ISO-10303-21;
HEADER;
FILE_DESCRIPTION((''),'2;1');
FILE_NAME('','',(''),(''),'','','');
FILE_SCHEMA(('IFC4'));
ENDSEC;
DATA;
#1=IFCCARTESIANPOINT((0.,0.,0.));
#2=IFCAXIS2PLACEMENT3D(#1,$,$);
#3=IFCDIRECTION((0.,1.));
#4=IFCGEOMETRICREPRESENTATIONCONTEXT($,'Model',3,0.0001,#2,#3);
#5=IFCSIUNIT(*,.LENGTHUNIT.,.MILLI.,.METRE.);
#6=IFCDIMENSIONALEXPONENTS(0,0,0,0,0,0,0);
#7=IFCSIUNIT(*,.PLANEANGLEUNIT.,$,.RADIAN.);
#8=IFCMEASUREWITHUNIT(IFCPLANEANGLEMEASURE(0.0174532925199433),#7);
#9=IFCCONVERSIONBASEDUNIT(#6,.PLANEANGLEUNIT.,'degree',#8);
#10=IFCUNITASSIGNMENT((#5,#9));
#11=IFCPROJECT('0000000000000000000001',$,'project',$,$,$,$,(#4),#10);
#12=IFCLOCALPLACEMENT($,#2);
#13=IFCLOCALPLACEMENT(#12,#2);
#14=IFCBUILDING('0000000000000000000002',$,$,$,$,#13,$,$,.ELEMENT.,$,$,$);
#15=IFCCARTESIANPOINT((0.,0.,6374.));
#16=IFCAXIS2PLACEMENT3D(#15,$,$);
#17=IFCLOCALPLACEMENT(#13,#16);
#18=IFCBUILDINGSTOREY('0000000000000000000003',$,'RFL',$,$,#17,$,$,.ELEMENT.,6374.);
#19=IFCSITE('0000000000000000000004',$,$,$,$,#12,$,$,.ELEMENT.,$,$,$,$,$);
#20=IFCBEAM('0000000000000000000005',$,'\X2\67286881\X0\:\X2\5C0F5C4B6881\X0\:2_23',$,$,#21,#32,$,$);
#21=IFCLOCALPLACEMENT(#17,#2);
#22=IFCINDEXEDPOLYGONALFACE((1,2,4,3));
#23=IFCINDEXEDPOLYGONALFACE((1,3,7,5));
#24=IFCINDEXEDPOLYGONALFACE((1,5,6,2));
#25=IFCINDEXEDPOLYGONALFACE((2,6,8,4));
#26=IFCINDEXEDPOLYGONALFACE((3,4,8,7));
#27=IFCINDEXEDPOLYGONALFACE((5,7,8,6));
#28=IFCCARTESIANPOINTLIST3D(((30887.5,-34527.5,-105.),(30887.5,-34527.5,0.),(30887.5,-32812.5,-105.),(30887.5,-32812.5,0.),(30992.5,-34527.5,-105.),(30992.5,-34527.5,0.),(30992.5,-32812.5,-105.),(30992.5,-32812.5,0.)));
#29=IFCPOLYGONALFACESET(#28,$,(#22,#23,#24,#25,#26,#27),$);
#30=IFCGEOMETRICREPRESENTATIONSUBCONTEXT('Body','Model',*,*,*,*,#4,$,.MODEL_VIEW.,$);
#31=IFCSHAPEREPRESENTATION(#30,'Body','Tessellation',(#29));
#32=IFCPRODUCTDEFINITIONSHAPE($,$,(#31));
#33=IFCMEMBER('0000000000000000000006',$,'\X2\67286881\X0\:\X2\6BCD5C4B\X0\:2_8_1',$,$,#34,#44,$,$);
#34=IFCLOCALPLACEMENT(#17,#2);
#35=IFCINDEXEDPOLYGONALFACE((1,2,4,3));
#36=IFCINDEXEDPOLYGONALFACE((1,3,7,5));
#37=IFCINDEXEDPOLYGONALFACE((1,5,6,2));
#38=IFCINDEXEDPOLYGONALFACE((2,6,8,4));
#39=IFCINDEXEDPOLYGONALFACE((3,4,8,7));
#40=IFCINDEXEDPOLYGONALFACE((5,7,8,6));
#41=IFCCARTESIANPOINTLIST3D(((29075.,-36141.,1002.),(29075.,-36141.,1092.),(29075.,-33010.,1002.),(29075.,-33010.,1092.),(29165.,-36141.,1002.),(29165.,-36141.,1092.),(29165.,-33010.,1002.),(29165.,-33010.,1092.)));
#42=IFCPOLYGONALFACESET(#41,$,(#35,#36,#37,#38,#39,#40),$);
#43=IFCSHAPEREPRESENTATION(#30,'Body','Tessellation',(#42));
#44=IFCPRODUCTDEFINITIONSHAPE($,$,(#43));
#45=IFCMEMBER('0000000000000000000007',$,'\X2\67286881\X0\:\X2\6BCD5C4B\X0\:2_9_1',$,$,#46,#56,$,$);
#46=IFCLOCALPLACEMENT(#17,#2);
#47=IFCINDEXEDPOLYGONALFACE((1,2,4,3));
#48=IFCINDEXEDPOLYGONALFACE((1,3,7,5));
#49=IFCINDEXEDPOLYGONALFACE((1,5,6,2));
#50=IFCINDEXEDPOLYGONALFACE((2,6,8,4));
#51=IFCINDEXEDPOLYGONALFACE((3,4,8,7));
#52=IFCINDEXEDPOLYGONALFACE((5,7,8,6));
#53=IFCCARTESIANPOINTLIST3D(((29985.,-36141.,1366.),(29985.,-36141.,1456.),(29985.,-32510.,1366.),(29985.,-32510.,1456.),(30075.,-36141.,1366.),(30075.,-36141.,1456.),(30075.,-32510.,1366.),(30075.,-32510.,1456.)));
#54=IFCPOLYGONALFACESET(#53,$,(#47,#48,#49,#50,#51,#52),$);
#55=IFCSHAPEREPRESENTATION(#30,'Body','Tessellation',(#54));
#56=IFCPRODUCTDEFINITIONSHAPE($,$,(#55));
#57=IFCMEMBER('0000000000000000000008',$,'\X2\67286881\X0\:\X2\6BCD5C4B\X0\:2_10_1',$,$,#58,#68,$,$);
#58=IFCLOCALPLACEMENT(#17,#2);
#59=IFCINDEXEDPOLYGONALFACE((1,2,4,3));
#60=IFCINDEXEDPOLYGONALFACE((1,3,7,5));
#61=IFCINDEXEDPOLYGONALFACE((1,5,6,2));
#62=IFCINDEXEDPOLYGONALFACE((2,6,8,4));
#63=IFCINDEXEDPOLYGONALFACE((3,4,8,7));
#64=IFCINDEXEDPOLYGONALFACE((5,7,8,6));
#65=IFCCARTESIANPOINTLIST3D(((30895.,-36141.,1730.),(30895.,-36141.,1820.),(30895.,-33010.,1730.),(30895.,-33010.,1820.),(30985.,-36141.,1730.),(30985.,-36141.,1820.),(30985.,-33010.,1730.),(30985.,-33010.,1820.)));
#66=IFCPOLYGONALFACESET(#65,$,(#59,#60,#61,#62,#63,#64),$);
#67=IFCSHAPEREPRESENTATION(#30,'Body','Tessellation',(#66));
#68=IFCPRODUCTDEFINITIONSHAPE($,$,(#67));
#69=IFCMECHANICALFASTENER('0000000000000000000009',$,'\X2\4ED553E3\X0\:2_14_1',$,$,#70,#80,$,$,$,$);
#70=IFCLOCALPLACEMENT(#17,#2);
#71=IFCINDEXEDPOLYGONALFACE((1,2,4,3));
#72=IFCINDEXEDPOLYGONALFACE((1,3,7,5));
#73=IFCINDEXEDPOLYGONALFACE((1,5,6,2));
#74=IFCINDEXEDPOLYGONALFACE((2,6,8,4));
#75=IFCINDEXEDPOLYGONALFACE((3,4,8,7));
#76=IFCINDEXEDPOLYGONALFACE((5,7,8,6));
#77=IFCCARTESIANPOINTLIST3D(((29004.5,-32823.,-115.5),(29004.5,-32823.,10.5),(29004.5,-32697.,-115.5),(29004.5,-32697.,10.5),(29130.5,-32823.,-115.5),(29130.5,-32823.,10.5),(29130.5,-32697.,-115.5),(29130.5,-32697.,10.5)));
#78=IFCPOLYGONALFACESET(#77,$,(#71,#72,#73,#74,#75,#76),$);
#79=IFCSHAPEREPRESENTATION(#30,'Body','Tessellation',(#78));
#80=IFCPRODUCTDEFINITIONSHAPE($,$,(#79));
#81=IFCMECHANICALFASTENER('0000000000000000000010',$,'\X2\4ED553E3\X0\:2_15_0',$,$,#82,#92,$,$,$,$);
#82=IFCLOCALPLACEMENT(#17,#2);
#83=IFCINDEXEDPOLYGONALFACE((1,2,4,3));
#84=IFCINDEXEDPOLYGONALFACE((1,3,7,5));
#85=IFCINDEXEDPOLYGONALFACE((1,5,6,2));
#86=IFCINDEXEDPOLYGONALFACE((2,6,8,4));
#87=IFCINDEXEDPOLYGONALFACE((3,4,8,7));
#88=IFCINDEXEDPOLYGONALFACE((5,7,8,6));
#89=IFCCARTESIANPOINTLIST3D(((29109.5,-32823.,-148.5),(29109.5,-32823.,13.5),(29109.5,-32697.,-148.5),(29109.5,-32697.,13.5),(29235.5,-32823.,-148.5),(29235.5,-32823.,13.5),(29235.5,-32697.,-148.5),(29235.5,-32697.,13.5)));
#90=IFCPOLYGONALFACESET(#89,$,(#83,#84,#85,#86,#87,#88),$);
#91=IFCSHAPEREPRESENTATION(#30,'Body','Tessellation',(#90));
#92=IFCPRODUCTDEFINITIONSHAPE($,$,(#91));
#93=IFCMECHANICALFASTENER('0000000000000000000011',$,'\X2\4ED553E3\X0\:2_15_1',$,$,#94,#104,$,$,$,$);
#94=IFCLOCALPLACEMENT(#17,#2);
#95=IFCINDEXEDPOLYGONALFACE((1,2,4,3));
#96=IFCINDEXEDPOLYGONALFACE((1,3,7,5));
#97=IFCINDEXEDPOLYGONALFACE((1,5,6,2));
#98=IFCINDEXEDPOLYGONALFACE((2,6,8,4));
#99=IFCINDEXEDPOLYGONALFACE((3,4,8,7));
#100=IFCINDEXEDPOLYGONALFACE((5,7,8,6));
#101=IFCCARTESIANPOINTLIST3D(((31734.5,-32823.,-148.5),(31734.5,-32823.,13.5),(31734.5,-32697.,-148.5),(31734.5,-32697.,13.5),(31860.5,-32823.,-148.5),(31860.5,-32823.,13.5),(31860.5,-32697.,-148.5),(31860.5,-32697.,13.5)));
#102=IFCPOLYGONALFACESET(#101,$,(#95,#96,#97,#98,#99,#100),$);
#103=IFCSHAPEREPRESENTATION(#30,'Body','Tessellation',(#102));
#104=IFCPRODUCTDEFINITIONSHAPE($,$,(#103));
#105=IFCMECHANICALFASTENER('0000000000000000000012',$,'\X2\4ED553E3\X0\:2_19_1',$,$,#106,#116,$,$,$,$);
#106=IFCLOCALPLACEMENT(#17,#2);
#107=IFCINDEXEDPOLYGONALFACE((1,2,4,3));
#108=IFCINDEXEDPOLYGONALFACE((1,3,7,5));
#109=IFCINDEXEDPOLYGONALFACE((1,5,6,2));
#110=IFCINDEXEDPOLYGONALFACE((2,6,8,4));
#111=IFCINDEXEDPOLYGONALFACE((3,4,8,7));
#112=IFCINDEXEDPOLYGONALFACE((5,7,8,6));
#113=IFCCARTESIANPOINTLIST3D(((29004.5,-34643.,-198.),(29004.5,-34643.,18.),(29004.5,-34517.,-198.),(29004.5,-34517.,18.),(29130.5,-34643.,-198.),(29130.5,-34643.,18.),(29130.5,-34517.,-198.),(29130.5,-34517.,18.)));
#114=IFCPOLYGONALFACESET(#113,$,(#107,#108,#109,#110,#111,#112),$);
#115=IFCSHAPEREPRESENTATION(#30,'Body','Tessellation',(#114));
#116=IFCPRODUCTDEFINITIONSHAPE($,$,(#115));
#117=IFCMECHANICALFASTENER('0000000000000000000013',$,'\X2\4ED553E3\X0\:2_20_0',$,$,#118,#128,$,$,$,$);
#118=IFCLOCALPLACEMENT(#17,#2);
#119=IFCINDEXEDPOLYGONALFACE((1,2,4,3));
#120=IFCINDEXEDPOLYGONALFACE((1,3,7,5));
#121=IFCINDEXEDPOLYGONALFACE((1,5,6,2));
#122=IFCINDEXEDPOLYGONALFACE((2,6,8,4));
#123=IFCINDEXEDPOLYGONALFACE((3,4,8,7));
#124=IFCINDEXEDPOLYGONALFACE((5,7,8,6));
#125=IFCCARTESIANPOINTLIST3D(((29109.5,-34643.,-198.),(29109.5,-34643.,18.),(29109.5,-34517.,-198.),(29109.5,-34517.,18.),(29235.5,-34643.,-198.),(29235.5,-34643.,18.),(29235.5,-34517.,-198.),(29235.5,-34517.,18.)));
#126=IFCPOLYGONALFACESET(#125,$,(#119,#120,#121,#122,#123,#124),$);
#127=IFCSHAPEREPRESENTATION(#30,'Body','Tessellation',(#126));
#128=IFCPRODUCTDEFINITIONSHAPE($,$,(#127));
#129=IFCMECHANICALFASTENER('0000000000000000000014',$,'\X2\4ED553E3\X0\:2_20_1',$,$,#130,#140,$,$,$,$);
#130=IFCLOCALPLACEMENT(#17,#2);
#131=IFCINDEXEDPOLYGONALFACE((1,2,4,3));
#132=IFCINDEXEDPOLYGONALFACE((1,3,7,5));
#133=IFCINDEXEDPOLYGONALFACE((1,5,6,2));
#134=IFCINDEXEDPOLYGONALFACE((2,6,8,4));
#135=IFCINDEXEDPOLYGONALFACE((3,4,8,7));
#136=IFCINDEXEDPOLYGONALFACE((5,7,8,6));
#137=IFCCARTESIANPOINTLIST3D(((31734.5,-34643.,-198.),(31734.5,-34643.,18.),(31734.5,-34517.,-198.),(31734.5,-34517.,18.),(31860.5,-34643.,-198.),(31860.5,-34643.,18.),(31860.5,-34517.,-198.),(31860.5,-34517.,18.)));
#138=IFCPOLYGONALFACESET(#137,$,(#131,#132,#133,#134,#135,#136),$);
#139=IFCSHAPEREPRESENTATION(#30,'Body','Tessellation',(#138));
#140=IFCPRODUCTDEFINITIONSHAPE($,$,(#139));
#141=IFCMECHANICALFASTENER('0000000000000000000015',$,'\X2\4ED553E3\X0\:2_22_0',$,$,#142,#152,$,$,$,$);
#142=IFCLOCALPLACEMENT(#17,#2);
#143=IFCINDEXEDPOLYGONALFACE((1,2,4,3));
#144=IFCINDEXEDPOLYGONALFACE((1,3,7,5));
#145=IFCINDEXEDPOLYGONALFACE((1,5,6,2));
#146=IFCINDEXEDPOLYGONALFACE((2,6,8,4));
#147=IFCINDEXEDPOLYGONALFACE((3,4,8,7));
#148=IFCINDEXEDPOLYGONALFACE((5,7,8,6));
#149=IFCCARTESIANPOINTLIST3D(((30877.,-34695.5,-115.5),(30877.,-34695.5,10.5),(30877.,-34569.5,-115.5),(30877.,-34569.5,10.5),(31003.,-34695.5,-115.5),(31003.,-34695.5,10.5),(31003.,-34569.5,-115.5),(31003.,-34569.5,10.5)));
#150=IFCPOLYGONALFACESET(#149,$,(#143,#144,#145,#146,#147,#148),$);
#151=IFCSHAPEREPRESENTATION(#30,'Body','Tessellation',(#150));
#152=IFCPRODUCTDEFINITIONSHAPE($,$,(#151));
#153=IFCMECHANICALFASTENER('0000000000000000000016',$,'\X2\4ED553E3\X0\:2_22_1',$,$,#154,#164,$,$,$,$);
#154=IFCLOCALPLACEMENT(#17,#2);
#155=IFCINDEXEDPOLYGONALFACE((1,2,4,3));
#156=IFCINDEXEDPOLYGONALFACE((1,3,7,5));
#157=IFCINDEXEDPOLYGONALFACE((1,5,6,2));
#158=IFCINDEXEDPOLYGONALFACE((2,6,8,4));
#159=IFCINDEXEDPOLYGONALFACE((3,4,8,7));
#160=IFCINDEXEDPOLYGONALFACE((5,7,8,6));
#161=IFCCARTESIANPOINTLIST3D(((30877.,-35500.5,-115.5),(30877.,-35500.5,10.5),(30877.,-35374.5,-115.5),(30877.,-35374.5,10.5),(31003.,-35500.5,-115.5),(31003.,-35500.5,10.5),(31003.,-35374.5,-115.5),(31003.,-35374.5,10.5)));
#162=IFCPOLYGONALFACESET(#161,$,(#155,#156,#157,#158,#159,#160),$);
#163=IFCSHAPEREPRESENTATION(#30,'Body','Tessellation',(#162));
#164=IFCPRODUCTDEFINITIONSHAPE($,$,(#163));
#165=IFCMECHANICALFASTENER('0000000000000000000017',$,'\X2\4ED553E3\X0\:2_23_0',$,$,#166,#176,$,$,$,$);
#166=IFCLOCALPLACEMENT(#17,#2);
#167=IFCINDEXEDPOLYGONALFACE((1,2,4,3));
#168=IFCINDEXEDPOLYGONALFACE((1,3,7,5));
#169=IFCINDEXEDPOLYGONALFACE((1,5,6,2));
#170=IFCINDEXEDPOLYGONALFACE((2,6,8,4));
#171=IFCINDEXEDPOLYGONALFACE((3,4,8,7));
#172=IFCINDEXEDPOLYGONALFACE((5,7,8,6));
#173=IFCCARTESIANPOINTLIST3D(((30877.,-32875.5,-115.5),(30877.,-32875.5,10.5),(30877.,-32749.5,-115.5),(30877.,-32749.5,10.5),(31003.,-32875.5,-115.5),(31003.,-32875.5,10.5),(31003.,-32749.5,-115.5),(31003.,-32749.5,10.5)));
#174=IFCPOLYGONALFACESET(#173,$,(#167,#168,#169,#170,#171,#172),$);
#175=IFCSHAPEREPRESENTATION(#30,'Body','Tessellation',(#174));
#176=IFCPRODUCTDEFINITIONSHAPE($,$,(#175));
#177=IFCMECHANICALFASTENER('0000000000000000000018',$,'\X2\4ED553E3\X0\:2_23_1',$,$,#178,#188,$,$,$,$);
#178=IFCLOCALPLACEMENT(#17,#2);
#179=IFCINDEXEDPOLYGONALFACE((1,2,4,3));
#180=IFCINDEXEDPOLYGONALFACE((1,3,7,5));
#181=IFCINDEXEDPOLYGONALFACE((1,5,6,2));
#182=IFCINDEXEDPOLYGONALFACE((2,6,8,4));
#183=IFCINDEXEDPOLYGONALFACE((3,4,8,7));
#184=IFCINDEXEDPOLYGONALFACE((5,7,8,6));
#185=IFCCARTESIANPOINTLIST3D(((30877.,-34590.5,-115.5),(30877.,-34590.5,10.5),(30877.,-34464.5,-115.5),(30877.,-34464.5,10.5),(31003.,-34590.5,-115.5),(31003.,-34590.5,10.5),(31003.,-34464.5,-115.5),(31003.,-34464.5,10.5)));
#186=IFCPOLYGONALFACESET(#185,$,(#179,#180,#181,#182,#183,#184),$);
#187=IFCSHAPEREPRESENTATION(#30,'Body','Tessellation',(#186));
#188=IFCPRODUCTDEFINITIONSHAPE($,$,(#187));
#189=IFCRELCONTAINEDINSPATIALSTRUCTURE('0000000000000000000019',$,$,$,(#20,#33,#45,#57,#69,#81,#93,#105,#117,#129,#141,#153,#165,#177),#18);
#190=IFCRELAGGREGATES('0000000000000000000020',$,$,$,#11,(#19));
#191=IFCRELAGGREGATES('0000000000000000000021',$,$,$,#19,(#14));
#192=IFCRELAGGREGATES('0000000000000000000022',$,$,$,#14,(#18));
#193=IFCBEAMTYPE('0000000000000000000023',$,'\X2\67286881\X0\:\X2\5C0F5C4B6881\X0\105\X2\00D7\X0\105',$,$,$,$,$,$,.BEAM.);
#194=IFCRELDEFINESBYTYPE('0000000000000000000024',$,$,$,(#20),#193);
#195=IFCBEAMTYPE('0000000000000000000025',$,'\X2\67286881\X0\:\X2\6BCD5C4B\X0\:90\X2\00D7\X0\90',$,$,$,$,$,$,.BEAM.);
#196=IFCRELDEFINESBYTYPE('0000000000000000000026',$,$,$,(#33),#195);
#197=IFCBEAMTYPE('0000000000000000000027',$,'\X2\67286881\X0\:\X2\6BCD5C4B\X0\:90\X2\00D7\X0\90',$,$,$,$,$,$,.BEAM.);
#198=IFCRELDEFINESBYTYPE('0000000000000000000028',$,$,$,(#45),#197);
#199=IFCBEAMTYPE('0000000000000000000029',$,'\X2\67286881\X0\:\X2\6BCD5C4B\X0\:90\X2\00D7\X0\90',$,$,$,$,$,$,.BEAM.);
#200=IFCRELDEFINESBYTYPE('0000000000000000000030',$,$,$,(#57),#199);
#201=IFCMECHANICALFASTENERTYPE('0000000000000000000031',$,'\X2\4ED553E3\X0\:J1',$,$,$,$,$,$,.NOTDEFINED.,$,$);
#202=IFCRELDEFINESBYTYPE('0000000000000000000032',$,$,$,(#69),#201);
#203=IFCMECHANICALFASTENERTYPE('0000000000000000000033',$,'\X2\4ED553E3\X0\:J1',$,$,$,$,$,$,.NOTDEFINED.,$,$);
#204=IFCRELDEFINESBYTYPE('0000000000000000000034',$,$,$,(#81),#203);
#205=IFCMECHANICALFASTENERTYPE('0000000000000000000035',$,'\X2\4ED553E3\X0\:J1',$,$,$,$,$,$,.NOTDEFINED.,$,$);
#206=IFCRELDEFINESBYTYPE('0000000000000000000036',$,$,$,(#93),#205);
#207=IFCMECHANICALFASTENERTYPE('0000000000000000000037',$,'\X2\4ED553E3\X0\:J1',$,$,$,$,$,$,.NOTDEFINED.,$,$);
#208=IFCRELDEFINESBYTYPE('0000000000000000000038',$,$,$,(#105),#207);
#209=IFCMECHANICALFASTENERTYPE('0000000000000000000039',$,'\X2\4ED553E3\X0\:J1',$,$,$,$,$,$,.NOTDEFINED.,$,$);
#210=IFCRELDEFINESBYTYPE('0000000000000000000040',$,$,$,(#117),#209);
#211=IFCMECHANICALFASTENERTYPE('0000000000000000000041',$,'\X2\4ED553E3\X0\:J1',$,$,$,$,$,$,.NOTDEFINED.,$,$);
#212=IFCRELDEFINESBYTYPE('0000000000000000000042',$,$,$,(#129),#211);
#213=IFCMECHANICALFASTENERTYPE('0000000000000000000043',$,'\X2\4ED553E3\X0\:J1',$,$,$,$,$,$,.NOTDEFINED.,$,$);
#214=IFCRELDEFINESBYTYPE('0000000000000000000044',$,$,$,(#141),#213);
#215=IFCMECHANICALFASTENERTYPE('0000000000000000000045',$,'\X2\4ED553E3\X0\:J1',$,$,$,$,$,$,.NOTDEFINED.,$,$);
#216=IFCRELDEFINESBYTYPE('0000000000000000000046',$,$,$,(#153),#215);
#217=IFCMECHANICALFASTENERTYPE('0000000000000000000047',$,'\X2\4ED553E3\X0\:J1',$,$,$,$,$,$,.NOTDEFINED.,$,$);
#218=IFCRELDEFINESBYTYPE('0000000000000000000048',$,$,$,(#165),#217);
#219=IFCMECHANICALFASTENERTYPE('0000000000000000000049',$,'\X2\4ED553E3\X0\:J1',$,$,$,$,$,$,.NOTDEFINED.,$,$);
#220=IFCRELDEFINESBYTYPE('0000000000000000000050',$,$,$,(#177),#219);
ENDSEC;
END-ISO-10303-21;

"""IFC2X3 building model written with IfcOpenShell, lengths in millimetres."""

from ifc_helpers import new_model, entity, si_unit, converted_unit, direction, frame, origin, origin_with_axes, origin_2d, place, context, subcontext, project, spatial, rectangle, extrude, type_object, element, save


model = new_model("IFC2X3")

# Units and contexts
model_context = context("Model", 3, precision=0.0001, world=origin(), true_north=direction((0.0, 1.0)))
body_context = subcontext(model_context, "Body", "Model", "MODEL_VIEW")
ifc_project = project(units=[si_unit("LENGTHUNIT", "METRE", prefix="MILLI"), converted_unit("PLANEANGLEUNIT", "degree", entity("IfcPlaneAngleMeasure", 0.0174532925199433), si_unit("PLANEANGLEUNIT", "RADIAN"), dimensions=[0, 0, 0, 0, 0, 0, 0])], contexts=[model_context])

# Site, building, storey
site_placement = place(None, origin())
site = spatial("IfcSite", under=ifc_project, at=site_placement, CompositionType="ELEMENT")
building_placement = place(site_placement, origin())
building = spatial("IfcBuilding", under=site, at=building_placement, CompositionType="ELEMENT")
storey_placement = place(building_placement, frame((0.0, 0.0, 6374.0)))
storey = spatial("IfcBuildingStorey", under=building, at=storey_placement, Name="RFL", CompositionType="ELEMENT", Elevation=6374.0)

# Beam
beam_type_1 = type_object("IfcBeamType", Name="木梁:小屋梁105×105", PredefinedType="BEAM")
beam_1_placement = place(storey_placement, frame((30940.0, -32812.5, -52.5), z_axis=(0.0, -1.0, 0.0), x_axis=(1.0, 0.0, 0.0)))
element("IfcBeam", 1, at=beam_1_placement, inside=storey, type_object=beam_type_1, Name="木梁:小屋梁:2_23", context=body_context, shape_type="SweptSolid", body=[
    extrude(rectangle(XDim=105.0, YDim=105.0, at=origin_2d()), origin_with_axes(), (0.0, 0.0, 1.0), 1715.0),
])

# Members
beam_type_2 = type_object("IfcBeamType", Name="木梁:母屋:90×90", PredefinedType="BEAM")
member_1_placement = place(storey_placement, frame((29120.0, -33010.0, 1047.0), z_axis=(0.0, -1.0, 0.0), x_axis=(-1.0, 0.0, 0.0)))
element("IfcMember", 2, at=member_1_placement, inside=storey, type_object=beam_type_2, Name="木梁:母屋:2_8_1", context=body_context, shape_type="SweptSolid", body=[
    extrude(rectangle(XDim=90.0, YDim=90.0, at=origin_2d()), origin_with_axes(), (0.0, 0.0, 1.0), 3131.0),
])
beam_type_3 = type_object("IfcBeamType", Name="木梁:母屋:90×90", PredefinedType="BEAM")
member_2_placement = place(storey_placement, frame((30030.0, -32510.0, 1411.0), z_axis=(0.0, -1.0, 0.0), x_axis=(-1.0, 0.0, 0.0)))
element("IfcMember", 3, at=member_2_placement, inside=storey, type_object=beam_type_3, Name="木梁:母屋:2_9_1", context=body_context, shape_type="SweptSolid", body=[
    extrude(rectangle(XDim=90.0, YDim=90.0, at=origin_2d()), origin_with_axes(), (0.0, 0.0, 1.0), 3631.0),
])
beam_type_4 = type_object("IfcBeamType", Name="木梁:母屋:90×90", PredefinedType="BEAM")
member_3_placement = place(storey_placement, frame((30940.0, -33010.0, 1775.0), z_axis=(0.0, -1.0, 0.0), x_axis=(-1.0, 0.0, 0.0)))
element("IfcMember", 4, at=member_3_placement, inside=storey, type_object=beam_type_4, Name="木梁:母屋:2_10_1", context=body_context, shape_type="SweptSolid", body=[
    extrude(rectangle(XDim=90.0, YDim=90.0, at=origin_2d()), origin_with_axes(), (0.0, 0.0, 1.0), 3131.0),
])

# Mechanical fasteners
mechanical_fastener_type_1 = type_object("IfcMechanicalFastenerType", Name="仕口:J1")
mechanical_fastener_1_placement = place(storey_placement, frame((29067.5, -32760.0, -115.5)))
element("IfcMechanicalFastener", 5, at=mechanical_fastener_1_placement, inside=storey, type_object=mechanical_fastener_type_1, Name="仕口:2_14_1", context=body_context, shape_type="SweptSolid", body=[
    extrude(rectangle(XDim=126.0, YDim=126.0, at=origin_2d()), origin_with_axes(), (0.0, 0.0, 1.0), 126.0),
])
mechanical_fastener_type_2 = type_object("IfcMechanicalFastenerType", Name="仕口:J1")
mechanical_fastener_2_placement = place(storey_placement, frame((29172.5, -32760.0, -148.5)))
element("IfcMechanicalFastener", 6, at=mechanical_fastener_2_placement, inside=storey, type_object=mechanical_fastener_type_2, Name="仕口:2_15_0", context=body_context, shape_type="SweptSolid", body=[
    extrude(rectangle(XDim=126.0, YDim=126.0, at=origin_2d()), origin_with_axes(), (0.0, 0.0, 1.0), 162.0),
])
mechanical_fastener_type_3 = type_object("IfcMechanicalFastenerType", Name="仕口:J1")
mechanical_fastener_3_placement = place(storey_placement, frame((31797.5, -32760.0, -148.5)))
element("IfcMechanicalFastener", 7, at=mechanical_fastener_3_placement, inside=storey, type_object=mechanical_fastener_type_3, Name="仕口:2_15_1", context=body_context, shape_type="SweptSolid", body=[
    extrude(rectangle(XDim=126.0, YDim=126.0, at=origin_2d()), origin_with_axes(), (0.0, 0.0, 1.0), 162.0),
])
mechanical_fastener_type_4 = type_object("IfcMechanicalFastenerType", Name="仕口:J1")
mechanical_fastener_4_placement = place(storey_placement, frame((29067.5, -34580.0, -198.0)))
element("IfcMechanicalFastener", 8, at=mechanical_fastener_4_placement, inside=storey, type_object=mechanical_fastener_type_4, Name="仕口:2_19_1", context=body_context, shape_type="SweptSolid", body=[
    extrude(rectangle(XDim=126.0, YDim=126.0, at=origin_2d()), origin_with_axes(), (0.0, 0.0, 1.0), 216.0),
])
mechanical_fastener_type_5 = type_object("IfcMechanicalFastenerType", Name="仕口:J1")
mechanical_fastener_5_placement = place(storey_placement, frame((29172.5, -34580.0, -198.0)))
element("IfcMechanicalFastener", 9, at=mechanical_fastener_5_placement, inside=storey, type_object=mechanical_fastener_type_5, Name="仕口:2_20_0", context=body_context, shape_type="SweptSolid", body=[
    extrude(rectangle(XDim=126.0, YDim=126.0, at=origin_2d()), origin_with_axes(), (0.0, 0.0, 1.0), 216.0),
])
mechanical_fastener_type_6 = type_object("IfcMechanicalFastenerType", Name="仕口:J1")
mechanical_fastener_6_placement = place(storey_placement, frame((31797.5, -34580.0, -198.0)))
element("IfcMechanicalFastener", 10, at=mechanical_fastener_6_placement, inside=storey, type_object=mechanical_fastener_type_6, Name="仕口:2_20_1", context=body_context, shape_type="SweptSolid", body=[
    extrude(rectangle(XDim=126.0, YDim=126.0, at=origin_2d()), origin_with_axes(), (0.0, 0.0, 1.0), 216.0),
])
mechanical_fastener_type_7 = type_object("IfcMechanicalFastenerType", Name="仕口:J1")
mechanical_fastener_7_placement = place(storey_placement, frame((30940.0, -34632.5, -115.5)))
element("IfcMechanicalFastener", 11, at=mechanical_fastener_7_placement, inside=storey, type_object=mechanical_fastener_type_7, Name="仕口:2_22_0", context=body_context, shape_type="SweptSolid", body=[
    extrude(rectangle(XDim=126.0, YDim=126.0, at=origin_2d()), origin_with_axes(), (0.0, 0.0, 1.0), 126.0),
])
mechanical_fastener_type_8 = type_object("IfcMechanicalFastenerType", Name="仕口:J1")
mechanical_fastener_8_placement = place(storey_placement, frame((30940.0, -35437.5, -115.5)))
element("IfcMechanicalFastener", 12, at=mechanical_fastener_8_placement, inside=storey, type_object=mechanical_fastener_type_8, Name="仕口:2_22_1", context=body_context, shape_type="SweptSolid", body=[
    extrude(rectangle(XDim=126.0, YDim=126.0, at=origin_2d()), origin_with_axes(), (0.0, 0.0, 1.0), 126.0),
])
mechanical_fastener_type_9 = type_object("IfcMechanicalFastenerType", Name="仕口:J1")
mechanical_fastener_9_placement = place(storey_placement, frame((30940.0, -32812.5, -115.5)))
element("IfcMechanicalFastener", 13, at=mechanical_fastener_9_placement, inside=storey, type_object=mechanical_fastener_type_9, Name="仕口:2_23_0", context=body_context, shape_type="SweptSolid", body=[
    extrude(rectangle(XDim=126.0, YDim=126.0, at=origin_2d()), origin_with_axes(), (0.0, 0.0, 1.0), 126.0),
])
mechanical_fastener_type_10 = type_object("IfcMechanicalFastenerType", Name="仕口:J1")
mechanical_fastener_10_placement = place(storey_placement, frame((30940.0, -34527.5, -115.5)))
element("IfcMechanicalFastener", 14, at=mechanical_fastener_10_placement, inside=storey, type_object=mechanical_fastener_type_10, Name="仕口:2_23_1", context=body_context, shape_type="SweptSolid", body=[
    extrude(rectangle(XDim=126.0, YDim=126.0, at=origin_2d()), origin_with_axes(), (0.0, 0.0, 1.0), 126.0),
])

save(model, "model.ifc")
